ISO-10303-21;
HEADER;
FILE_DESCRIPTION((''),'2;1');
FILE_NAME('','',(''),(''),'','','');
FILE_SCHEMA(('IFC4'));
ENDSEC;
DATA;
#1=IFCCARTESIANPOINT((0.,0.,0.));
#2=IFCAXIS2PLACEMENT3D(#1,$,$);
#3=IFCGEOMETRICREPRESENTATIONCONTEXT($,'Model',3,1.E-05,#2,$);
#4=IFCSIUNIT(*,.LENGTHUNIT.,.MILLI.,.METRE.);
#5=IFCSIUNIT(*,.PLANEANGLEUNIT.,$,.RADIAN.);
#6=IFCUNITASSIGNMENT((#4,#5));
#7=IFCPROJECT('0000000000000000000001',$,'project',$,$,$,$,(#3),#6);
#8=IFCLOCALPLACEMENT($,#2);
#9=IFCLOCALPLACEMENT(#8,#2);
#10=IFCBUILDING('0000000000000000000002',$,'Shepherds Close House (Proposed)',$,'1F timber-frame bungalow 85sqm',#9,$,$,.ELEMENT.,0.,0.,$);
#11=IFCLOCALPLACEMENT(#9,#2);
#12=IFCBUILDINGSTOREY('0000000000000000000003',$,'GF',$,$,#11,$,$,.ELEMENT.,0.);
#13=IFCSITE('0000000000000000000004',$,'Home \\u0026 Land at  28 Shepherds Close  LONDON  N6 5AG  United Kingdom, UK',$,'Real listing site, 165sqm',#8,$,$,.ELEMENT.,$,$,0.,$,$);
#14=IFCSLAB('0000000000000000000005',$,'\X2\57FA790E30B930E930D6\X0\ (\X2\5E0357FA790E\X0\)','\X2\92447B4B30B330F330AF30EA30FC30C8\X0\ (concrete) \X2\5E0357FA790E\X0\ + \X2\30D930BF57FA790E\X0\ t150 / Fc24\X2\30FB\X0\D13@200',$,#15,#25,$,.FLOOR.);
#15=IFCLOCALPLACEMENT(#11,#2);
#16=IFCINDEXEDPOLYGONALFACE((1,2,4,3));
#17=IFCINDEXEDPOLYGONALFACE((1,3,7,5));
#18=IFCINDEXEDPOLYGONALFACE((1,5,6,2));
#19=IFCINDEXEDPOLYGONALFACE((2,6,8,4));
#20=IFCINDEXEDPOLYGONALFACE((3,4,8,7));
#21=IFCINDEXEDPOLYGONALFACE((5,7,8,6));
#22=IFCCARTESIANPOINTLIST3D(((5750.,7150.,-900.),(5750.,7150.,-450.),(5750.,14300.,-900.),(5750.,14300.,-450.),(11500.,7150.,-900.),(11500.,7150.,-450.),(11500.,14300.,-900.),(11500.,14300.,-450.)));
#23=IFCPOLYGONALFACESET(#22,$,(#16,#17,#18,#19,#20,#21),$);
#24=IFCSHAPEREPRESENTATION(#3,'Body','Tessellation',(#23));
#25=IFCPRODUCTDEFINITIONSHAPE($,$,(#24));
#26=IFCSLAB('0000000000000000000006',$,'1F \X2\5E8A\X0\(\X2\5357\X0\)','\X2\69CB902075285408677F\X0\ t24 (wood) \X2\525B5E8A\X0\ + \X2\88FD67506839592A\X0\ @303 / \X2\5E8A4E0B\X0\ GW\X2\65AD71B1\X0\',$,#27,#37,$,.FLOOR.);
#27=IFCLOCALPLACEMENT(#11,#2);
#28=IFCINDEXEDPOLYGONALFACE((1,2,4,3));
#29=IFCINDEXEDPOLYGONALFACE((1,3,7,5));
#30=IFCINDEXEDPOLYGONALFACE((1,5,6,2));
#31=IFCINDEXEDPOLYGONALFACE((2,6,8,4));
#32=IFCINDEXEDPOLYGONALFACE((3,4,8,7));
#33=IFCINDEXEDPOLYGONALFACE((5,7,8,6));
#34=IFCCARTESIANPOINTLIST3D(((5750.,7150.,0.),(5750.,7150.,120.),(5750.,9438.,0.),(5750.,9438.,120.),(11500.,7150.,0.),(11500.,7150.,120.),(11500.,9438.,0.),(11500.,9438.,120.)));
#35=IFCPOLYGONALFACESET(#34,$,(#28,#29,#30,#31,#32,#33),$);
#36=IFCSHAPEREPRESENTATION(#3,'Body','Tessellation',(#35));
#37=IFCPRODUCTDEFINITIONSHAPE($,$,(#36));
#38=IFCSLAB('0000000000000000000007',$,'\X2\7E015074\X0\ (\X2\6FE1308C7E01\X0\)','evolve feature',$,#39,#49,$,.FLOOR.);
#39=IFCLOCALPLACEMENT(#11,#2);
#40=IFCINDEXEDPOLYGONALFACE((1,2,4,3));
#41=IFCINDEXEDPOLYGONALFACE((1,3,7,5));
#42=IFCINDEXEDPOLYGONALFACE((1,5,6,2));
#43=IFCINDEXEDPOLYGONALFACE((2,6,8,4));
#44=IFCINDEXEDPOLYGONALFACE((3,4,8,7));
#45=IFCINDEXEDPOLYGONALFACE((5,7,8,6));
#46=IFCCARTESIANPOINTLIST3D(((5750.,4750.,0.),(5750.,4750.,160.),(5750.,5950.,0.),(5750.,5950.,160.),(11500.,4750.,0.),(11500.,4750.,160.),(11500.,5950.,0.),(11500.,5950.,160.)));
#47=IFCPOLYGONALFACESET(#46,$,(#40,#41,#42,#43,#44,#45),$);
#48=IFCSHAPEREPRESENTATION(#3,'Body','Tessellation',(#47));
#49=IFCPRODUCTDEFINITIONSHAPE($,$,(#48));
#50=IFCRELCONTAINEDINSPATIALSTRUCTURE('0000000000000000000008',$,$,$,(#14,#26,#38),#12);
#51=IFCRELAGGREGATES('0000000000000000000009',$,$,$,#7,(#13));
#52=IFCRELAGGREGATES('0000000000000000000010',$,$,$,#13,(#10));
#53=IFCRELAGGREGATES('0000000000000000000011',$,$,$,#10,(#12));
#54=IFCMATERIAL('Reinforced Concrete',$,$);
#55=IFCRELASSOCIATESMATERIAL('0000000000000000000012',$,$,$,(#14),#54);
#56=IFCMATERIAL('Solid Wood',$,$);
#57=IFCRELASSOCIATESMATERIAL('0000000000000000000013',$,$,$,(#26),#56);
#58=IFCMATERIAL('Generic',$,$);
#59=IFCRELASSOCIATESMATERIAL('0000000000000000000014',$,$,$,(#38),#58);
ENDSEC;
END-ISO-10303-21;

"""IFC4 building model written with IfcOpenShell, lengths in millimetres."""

from ifc_helpers import new_model, si_unit, frame, frame_2d, origin, place, context, project, spatial, rectangle, extrude, material, element, save


model = new_model("IFC4")

# Units and contexts
model_context = context("Model", 3, precision=1e-05, world=origin())
ifc_project = project(units=[si_unit("LENGTHUNIT", "METRE", prefix="MILLI"), si_unit("PLANEANGLEUNIT", "RADIAN")], contexts=[model_context])

# Site, building, storey
site_placement = place(None, origin())
site = spatial("IfcSite", under=ifc_project, at=site_placement, Name="Home \\u0026 Land at  28 Shepherds Close  LONDON  N6 5AG  United Kingdom, UK", ObjectType="Real listing site, 165sqm", CompositionType="ELEMENT", RefElevation=0.0)
building_placement = place(site_placement, origin())
building = spatial("IfcBuilding", under=site, at=building_placement, Name="Shepherds Close House (Proposed)", ObjectType="1F timber-frame bungalow 85sqm", CompositionType="ELEMENT", ElevationOfRefHeight=0.0, ElevationOfTerrain=0.0)
storey_placement = place(building_placement, origin())
storey = spatial("IfcBuildingStorey", under=building, at=storey_placement, Name="GF", CompositionType="ELEMENT", Elevation=0.0)

# Slabs
ifc_material_1 = material(Name="Reinforced Concrete")
slab_1_placement = place(storey_placement, frame((2875.0, 3575.0, -450.0)))
element("IfcSlab", 1, at=slab_1_placement, inside=storey, material=ifc_material_1, Name="基礎スラブ (布基礎)", Description="鉄筋コンクリート (concrete) 布基礎 + ベタ基礎 t150 / Fc24・D13@200", PredefinedType="FLOOR", context=model_context, shape_type="SweptSolid", body=[
    extrude(rectangle(XDim=5750.0, YDim=7150.0, at=frame_2d((2875.0, 3575.0))), frame((2875.0, 3575.0, -450.0)), (0.0, 0.0, 1.0), 450.0),
])
ifc_material_2 = material(Name="Solid Wood")
slab_2_placement = place(storey_placement, frame((2875.0, 3575.0, 0.0)))
element("IfcSlab", 2, at=slab_2_placement, inside=storey, material=ifc_material_2, Name="1F 床(南)", Description="構造用合板 t24 (wood) 剛床 + 製材根太 @303 / 床下 GW断熱", PredefinedType="FLOOR", context=model_context, shape_type="SweptSolid", body=[
    extrude(rectangle(XDim=5750.0, YDim=2288.0, at=frame_2d((2875.0, 1144.0))), frame((2875.0, 3575.0, 0.0)), (0.0, 0.0, 1.0), 120.0),
])
ifc_material_3 = material(Name="Generic")
slab_3_placement = place(storey_placement, frame((2875.0, 2375.0, 0.0)))
element("IfcSlab", 3, at=slab_3_placement, inside=storey, material=ifc_material_3, Name="縁側 (濡れ縁)", Description="evolve feature", PredefinedType="FLOOR", context=model_context, shape_type="SweptSolid", body=[
    extrude(rectangle(XDim=5750.0, YDim=1200.0, at=frame_2d((2875.0, 600.0))), frame((2875.0, 2375.0, 0.0)), (0.0, 0.0, 1.0), 160.0),
])

save(model, "model.ifc")
